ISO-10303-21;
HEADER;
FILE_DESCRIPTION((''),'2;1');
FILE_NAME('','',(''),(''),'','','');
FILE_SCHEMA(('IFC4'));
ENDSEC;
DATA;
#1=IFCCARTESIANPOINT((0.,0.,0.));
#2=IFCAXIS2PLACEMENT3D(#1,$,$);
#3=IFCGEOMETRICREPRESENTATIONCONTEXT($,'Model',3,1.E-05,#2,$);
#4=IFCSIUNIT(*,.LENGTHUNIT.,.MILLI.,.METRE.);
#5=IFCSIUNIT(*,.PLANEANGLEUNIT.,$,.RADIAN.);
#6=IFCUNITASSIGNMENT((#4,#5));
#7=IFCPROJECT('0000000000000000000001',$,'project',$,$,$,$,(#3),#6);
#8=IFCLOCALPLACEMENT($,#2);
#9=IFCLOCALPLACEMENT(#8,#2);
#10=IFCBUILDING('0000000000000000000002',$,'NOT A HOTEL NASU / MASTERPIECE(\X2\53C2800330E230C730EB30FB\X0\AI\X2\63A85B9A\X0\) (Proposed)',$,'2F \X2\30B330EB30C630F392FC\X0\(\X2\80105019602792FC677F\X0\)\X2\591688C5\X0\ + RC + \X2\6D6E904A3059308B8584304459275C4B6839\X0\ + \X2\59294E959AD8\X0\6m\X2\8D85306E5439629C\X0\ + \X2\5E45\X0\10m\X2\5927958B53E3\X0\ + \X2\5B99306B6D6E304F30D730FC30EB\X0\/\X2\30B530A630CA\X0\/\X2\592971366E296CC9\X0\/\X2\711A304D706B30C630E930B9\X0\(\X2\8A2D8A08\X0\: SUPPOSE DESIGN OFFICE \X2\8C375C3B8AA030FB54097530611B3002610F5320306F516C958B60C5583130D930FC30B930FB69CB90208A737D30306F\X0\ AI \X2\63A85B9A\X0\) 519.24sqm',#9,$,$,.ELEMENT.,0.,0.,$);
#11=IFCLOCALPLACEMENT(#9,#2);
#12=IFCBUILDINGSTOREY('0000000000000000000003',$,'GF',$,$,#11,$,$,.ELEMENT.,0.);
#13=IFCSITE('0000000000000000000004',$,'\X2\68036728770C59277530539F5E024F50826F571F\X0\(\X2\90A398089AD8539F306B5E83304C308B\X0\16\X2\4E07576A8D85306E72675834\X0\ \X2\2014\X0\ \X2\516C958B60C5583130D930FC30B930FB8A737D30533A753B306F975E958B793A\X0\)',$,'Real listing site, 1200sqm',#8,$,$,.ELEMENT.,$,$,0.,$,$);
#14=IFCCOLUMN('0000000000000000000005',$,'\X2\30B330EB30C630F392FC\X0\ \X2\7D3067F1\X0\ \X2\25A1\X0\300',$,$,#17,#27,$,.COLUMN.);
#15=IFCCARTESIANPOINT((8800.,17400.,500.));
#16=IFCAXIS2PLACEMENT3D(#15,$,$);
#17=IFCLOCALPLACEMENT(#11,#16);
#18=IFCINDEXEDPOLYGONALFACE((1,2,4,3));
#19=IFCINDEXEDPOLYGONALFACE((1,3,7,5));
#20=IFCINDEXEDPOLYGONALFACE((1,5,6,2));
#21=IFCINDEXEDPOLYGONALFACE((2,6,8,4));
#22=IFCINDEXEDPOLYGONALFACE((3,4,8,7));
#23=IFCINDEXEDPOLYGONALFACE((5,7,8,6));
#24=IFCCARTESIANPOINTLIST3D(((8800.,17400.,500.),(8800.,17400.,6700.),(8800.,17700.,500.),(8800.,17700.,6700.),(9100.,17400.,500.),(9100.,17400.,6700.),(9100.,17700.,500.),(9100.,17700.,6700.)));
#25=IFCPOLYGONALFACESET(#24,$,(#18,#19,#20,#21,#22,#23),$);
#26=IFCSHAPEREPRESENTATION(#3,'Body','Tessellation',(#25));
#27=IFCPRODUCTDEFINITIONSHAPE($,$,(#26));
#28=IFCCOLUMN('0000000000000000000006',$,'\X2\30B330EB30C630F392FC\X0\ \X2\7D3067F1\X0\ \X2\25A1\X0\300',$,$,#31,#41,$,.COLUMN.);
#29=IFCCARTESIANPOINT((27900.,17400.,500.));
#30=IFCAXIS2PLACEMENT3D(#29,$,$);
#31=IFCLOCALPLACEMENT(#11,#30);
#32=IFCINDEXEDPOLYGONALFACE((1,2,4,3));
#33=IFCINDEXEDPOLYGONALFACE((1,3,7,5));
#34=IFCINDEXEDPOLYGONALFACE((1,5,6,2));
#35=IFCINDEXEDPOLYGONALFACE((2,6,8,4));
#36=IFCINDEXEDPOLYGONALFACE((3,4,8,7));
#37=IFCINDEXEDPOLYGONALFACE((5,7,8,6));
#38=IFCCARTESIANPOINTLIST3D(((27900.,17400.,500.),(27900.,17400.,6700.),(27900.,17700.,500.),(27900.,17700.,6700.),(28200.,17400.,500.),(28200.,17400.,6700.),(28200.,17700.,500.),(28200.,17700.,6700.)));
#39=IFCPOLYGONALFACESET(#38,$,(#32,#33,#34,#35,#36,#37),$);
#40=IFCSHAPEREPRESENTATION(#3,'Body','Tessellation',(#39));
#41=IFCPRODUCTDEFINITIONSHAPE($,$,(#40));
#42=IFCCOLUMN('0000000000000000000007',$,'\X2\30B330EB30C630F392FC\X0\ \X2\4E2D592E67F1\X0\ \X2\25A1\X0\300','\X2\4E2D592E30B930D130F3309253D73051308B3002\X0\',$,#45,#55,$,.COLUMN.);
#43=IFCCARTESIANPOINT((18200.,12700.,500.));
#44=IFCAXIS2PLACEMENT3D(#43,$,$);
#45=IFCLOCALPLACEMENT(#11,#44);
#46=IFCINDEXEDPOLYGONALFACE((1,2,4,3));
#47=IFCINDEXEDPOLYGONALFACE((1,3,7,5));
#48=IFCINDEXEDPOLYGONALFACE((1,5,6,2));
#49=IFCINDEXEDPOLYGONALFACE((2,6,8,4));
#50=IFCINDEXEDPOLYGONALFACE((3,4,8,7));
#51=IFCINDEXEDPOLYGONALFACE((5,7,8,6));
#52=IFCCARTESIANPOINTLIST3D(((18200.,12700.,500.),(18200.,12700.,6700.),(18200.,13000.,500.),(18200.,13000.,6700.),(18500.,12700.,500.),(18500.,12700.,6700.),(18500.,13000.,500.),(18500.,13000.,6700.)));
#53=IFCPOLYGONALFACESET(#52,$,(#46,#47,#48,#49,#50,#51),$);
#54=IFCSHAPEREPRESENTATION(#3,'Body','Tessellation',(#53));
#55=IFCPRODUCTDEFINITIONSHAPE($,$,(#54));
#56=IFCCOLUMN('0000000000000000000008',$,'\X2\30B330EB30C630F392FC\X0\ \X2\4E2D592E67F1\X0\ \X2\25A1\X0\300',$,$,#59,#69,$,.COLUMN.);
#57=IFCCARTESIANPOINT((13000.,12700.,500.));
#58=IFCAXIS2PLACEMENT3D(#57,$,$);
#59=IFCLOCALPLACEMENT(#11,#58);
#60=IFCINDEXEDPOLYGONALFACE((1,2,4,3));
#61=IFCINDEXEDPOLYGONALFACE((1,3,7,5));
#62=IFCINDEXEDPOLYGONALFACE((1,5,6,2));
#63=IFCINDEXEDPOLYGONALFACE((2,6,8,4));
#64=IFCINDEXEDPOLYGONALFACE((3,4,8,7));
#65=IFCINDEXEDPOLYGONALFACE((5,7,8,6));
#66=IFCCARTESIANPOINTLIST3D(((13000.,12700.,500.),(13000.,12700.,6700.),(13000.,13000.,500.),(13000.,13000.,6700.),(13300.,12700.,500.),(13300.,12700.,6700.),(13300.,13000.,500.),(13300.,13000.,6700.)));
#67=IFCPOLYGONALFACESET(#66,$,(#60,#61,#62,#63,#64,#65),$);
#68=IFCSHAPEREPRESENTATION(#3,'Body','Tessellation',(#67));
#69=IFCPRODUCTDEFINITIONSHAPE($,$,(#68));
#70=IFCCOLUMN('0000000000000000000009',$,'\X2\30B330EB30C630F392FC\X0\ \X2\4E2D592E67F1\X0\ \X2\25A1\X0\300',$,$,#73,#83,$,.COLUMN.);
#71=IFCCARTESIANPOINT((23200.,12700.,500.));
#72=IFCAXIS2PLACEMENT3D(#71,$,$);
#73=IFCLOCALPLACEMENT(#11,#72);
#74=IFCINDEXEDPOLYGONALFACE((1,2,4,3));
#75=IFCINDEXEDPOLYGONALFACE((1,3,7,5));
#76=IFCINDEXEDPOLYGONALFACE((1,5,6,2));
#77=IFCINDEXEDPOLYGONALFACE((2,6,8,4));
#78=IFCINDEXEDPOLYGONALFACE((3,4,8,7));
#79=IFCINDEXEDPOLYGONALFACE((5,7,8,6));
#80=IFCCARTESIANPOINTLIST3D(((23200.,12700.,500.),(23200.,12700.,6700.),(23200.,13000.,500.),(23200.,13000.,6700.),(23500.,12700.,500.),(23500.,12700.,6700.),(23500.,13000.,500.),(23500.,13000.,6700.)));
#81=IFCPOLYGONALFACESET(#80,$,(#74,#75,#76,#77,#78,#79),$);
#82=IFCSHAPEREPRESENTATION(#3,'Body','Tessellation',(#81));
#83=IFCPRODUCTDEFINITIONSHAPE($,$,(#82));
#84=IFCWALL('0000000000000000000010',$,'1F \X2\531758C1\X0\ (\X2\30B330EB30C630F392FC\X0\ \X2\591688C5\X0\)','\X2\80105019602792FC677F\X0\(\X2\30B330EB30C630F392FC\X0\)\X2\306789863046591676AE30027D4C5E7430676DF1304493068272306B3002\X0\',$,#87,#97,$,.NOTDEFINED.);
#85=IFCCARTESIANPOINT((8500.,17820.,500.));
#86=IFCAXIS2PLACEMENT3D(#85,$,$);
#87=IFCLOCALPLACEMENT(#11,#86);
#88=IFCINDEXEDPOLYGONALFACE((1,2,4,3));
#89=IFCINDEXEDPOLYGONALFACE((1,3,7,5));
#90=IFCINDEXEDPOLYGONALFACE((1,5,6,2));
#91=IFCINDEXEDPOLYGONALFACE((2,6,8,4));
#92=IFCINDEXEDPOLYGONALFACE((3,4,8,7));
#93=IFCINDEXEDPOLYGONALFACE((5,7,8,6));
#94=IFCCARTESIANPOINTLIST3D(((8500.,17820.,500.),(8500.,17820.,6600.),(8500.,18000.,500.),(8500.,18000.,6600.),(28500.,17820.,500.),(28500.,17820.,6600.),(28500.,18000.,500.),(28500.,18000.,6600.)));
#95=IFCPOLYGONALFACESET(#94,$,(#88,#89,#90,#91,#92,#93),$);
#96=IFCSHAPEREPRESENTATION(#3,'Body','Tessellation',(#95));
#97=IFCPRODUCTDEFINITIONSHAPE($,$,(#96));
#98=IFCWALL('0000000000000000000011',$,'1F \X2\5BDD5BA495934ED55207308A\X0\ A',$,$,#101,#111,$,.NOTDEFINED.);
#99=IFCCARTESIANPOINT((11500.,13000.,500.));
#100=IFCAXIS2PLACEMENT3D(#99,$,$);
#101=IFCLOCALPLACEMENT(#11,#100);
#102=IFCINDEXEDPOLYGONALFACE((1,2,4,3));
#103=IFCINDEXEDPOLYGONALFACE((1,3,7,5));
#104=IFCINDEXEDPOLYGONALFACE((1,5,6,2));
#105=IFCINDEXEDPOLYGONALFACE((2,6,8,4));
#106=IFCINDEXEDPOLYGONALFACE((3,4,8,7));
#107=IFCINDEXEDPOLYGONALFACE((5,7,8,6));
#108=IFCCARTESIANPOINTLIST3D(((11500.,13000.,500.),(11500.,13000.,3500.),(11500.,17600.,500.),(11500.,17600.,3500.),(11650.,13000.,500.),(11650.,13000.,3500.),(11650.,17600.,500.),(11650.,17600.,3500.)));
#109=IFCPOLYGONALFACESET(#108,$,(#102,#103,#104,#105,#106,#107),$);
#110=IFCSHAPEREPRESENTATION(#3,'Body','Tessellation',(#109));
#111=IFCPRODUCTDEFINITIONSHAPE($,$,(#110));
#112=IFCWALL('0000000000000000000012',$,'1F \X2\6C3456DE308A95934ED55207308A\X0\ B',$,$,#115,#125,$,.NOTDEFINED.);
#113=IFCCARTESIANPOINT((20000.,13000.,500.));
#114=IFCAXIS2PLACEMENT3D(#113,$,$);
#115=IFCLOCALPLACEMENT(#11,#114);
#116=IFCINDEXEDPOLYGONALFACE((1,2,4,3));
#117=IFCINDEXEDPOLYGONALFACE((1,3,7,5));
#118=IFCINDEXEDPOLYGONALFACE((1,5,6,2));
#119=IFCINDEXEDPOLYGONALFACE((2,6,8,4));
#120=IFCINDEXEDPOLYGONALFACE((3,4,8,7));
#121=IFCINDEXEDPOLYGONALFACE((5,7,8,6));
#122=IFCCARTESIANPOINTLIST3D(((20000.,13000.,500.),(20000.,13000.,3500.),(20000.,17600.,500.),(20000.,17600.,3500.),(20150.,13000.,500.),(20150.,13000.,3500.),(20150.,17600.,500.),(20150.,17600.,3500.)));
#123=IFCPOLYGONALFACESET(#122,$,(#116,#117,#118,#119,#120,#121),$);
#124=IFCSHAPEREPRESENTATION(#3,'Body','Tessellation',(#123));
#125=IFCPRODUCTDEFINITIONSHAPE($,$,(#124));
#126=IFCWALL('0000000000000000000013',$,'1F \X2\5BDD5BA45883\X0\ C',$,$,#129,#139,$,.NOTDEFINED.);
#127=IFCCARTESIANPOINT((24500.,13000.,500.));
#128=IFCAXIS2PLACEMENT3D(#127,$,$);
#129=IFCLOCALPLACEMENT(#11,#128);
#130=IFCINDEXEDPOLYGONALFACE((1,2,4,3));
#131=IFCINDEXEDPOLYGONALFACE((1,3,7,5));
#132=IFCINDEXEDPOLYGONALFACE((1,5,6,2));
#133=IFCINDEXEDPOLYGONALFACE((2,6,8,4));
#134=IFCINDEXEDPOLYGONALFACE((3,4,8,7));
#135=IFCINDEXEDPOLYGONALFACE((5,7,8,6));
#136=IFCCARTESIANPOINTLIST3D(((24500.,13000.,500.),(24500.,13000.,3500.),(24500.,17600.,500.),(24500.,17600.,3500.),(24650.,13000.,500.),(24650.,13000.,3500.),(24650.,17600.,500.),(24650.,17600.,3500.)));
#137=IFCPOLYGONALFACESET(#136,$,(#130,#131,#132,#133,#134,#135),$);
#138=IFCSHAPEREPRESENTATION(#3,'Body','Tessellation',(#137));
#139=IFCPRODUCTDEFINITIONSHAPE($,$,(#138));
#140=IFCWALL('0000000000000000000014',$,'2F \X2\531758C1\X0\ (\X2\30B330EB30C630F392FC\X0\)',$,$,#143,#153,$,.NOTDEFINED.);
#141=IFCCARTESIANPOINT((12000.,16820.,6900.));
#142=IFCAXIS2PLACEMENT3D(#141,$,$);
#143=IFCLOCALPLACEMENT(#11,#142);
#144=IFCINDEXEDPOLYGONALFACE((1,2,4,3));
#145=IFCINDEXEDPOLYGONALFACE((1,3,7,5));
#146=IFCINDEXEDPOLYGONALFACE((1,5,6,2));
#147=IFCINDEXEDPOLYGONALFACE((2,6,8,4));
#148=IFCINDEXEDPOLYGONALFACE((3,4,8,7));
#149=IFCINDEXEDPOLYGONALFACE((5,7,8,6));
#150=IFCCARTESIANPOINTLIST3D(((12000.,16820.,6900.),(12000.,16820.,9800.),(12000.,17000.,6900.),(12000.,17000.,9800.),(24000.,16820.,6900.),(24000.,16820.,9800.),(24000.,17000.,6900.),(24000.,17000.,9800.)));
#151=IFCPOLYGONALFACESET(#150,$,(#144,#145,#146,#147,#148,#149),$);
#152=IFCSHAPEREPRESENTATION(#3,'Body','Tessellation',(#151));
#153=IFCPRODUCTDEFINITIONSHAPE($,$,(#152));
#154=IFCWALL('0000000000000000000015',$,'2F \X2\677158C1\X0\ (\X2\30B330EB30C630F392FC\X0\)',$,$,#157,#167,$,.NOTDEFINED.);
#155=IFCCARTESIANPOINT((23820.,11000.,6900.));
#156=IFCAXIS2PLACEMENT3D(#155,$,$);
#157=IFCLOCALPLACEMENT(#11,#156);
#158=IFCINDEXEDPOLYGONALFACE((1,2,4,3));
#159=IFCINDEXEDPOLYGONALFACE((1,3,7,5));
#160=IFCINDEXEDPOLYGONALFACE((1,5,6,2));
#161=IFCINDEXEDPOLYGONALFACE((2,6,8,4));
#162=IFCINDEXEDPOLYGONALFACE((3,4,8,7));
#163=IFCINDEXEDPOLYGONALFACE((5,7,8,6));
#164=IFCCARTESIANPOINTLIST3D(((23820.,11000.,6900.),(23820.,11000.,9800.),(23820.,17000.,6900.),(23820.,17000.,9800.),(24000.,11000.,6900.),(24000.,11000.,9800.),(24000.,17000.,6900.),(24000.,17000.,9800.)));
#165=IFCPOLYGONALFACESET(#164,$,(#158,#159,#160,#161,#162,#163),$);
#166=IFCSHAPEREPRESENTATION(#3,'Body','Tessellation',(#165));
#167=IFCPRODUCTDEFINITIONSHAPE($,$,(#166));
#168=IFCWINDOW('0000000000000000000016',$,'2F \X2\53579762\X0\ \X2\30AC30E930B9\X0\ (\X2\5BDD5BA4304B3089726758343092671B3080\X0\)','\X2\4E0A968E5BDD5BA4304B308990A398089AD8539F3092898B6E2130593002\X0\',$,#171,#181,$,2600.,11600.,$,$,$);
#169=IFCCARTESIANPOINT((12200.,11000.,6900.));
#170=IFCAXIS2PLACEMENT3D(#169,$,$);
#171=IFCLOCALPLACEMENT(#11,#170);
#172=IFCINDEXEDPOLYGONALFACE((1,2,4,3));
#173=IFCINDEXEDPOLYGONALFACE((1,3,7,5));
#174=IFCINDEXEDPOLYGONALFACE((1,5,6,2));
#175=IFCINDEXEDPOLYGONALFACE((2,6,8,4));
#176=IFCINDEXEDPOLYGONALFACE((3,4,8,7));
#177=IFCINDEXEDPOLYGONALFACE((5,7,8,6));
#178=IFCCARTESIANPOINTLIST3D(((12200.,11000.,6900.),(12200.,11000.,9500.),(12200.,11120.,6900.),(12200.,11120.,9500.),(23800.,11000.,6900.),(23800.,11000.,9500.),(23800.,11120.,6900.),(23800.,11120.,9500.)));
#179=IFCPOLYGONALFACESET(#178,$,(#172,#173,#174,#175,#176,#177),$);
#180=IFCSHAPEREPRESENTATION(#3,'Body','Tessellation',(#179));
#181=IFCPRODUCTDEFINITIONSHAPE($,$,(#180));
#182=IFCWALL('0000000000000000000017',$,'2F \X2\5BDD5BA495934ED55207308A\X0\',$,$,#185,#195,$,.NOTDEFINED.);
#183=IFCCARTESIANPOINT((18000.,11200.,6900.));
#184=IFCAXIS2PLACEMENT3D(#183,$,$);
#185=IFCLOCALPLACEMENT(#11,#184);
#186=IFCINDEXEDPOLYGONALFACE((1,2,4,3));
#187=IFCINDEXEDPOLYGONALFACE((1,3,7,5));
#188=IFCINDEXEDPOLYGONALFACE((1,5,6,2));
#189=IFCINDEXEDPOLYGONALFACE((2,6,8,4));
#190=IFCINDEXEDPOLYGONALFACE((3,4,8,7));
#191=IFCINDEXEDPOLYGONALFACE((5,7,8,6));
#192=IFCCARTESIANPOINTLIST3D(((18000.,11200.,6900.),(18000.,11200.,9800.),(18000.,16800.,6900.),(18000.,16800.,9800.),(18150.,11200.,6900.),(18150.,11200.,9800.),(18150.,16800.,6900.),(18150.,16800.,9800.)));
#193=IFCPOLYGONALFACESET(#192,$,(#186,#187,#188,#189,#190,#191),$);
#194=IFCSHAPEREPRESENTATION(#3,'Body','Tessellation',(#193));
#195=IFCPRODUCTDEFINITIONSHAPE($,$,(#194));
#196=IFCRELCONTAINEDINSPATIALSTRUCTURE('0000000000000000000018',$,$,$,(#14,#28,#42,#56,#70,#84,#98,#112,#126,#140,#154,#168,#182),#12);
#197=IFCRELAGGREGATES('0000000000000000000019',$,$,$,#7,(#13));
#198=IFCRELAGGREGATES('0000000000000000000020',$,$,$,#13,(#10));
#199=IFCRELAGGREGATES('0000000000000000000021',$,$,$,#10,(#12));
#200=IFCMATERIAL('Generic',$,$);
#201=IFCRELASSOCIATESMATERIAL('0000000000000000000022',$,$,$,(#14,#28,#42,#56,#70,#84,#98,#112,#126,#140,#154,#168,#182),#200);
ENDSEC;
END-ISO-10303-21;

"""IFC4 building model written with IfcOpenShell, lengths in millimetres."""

from ifc_helpers import new_model, si_unit, frame, frame_2d, origin, place, context, project, spatial, rectangle, extrude, material, element, save


model = new_model("IFC4")

# Units and contexts
model_context = context("Model", 3, precision=1e-05, world=origin())
ifc_project = project(units=[si_unit("LENGTHUNIT", "METRE", prefix="MILLI"), si_unit("PLANEANGLEUNIT", "RADIAN")], contexts=[model_context])

# Site, building, storey
site_placement = place(None, origin())
site = spatial("IfcSite", under=ifc_project, at=site_placement, Name="栃木県大田原市佐良土(那須高原に広がる16万坪超の牧場 — 公開情報ベース・詳細区画は非開示)", ObjectType="Real listing site, 1200sqm", CompositionType="ELEMENT", RefElevation=0.0)
building_placement = place(site_placement, origin())
building = spatial("IfcBuilding", under=site, at=building_placement, Name="NOT A HOTEL NASU / MASTERPIECE(参考モデル・AI推定) (Proposed)", ObjectType="2F コルテン鋼(耐候性鋼板)外装 + RC + 浮遊する薄い大屋根 + 天井高6m超の吹抜 + 幅10m大開口 + 宙に浮くプール/サウナ/天然温泉/焚き火テラス(設計: SUPPOSE DESIGN OFFICE 谷尻誠・吉田愛。意匠は公開情報ベース・構造詳細は AI 推定) 519.24sqm", CompositionType="ELEMENT", ElevationOfRefHeight=0.0, ElevationOfTerrain=0.0)
storey_placement = place(building_placement, origin())
storey = spatial("IfcBuildingStorey", under=building, at=storey_placement, Name="GF", CompositionType="ELEMENT", Elevation=0.0)

# Columns
ifc_material_1 = material(Name="Generic")
column_1_placement = place(storey_placement, frame((8800.0, 17400.0, 500.0)))
element("IfcColumn", 1, at=column_1_placement, inside=storey, material=ifc_material_1, Name="コルテン鋼 細柱 □300", PredefinedType="COLUMN", context=model_context, shape_type="SweptSolid", body=[
    extrude(rectangle(XDim=300.0, YDim=300.0, at=frame_2d((150.0, 150.0))), frame((8800.0, 17400.0, 500.0)), (0.0, 0.0, 1.0), 6200.0),
])
column_2_placement = place(storey_placement, frame((27900.0, 17400.0, 500.0)))
element("IfcColumn", 2, at=column_2_placement, inside=storey, material=ifc_material_1, Name="コルテン鋼 細柱 □300", PredefinedType="COLUMN", context=model_context, shape_type="SweptSolid", body=[
    extrude(rectangle(XDim=300.0, YDim=300.0, at=frame_2d((150.0, 150.0))), frame((27900.0, 17400.0, 500.0)), (0.0, 0.0, 1.0), 6200.0),
])
column_3_placement = place(storey_placement, frame((18200.0, 12700.0, 500.0)))
element("IfcColumn", 3, at=column_3_placement, inside=storey, material=ifc_material_1, Name="コルテン鋼 中央柱 □300", Description="中央スパンを受ける。", PredefinedType="COLUMN", context=model_context, shape_type="SweptSolid", body=[
    extrude(rectangle(XDim=300.0, YDim=300.0, at=frame_2d((150.0, 150.0))), frame((18200.0, 12700.0, 500.0)), (0.0, 0.0, 1.0), 6200.0),
])
column_4_placement = place(storey_placement, frame((13000.0, 12700.0, 500.0)))
element("IfcColumn", 4, at=column_4_placement, inside=storey, material=ifc_material_1, Name="コルテン鋼 中央柱 □300", PredefinedType="COLUMN", context=model_context, shape_type="SweptSolid", body=[
    extrude(rectangle(XDim=300.0, YDim=300.0, at=frame_2d((150.0, 150.0))), frame((13000.0, 12700.0, 500.0)), (0.0, 0.0, 1.0), 6200.0),
])
column_5_placement = place(storey_placement, frame((23200.0, 12700.0, 500.0)))
element("IfcColumn", 5, at=column_5_placement, inside=storey, material=ifc_material_1, Name="コルテン鋼 中央柱 □300", PredefinedType="COLUMN", context=model_context, shape_type="SweptSolid", body=[
    extrude(rectangle(XDim=300.0, YDim=300.0, at=frame_2d((150.0, 150.0))), frame((23200.0, 12700.0, 500.0)), (0.0, 0.0, 1.0), 6200.0),
])

# Walls
wall_1_placement = place(storey_placement, frame((8500.0, 17820.0, 500.0)))
element("IfcWall", 6, at=wall_1_placement, inside=storey, material=ifc_material_1, Name="1F 北壁 (コルテン鋼 外装)", Description="耐候性鋼板(コルテン鋼)で覆う外皮。経年で深い錆色に。", PredefinedType="NOTDEFINED", context=model_context, shape_type="SweptSolid", body=[
    extrude(rectangle(XDim=20000.0, YDim=180.0, at=frame_2d((10000.0, 90.0))), frame((8500.0, 17820.0, 500.0)), (0.0, 0.0, 1.0), 6100.0),
])
wall_2_placement = place(storey_placement, frame((11500.0, 13000.0, 500.0)))
element("IfcWall", 7, at=wall_2_placement, inside=storey, material=ifc_material_1, Name="1F 寝室間仕切り A", PredefinedType="NOTDEFINED", context=model_context, shape_type="SweptSolid", body=[
    extrude(rectangle(XDim=150.0, YDim=4600.0, at=frame_2d((75.0, 2300.0))), frame((11500.0, 13000.0, 500.0)), (0.0, 0.0, 1.0), 3000.0),
])
wall_3_placement = place(storey_placement, frame((20000.0, 13000.0, 500.0)))
element("IfcWall", 8, at=wall_3_placement, inside=storey, material=ifc_material_1, Name="1F 水回り間仕切り B", PredefinedType="NOTDEFINED", context=model_context, shape_type="SweptSolid", body=[
    extrude(rectangle(XDim=150.0, YDim=4600.0, at=frame_2d((75.0, 2300.0))), frame((20000.0, 13000.0, 500.0)), (0.0, 0.0, 1.0), 3000.0),
])
wall_4_placement = place(storey_placement, frame((24500.0, 13000.0, 500.0)))
element("IfcWall", 9, at=wall_4_placement, inside=storey, material=ifc_material_1, Name="1F 寝室境 C", PredefinedType="NOTDEFINED", context=model_context, shape_type="SweptSolid", body=[
    extrude(rectangle(XDim=150.0, YDim=4600.0, at=frame_2d((75.0, 2300.0))), frame((24500.0, 13000.0, 500.0)), (0.0, 0.0, 1.0), 3000.0),
])
wall_5_placement = place(storey_placement, frame((12000.0, 16820.0, 6900.0)))
element("IfcWall", 10, at=wall_5_placement, inside=storey, material=ifc_material_1, Name="2F 北壁 (コルテン鋼)", PredefinedType="NOTDEFINED", context=model_context, shape_type="SweptSolid", body=[
    extrude(rectangle(XDim=12000.0, YDim=180.0, at=frame_2d((6000.0, 90.0))), frame((12000.0, 16820.0, 6900.0)), (0.0, 0.0, 1.0), 2900.0),
])
wall_6_placement = place(storey_placement, frame((23820.0, 11000.0, 6900.0)))
element("IfcWall", 11, at=wall_6_placement, inside=storey, material=ifc_material_1, Name="2F 東壁 (コルテン鋼)", PredefinedType="NOTDEFINED", context=model_context, shape_type="SweptSolid", body=[
    extrude(rectangle(XDim=180.0, YDim=6000.0, at=frame_2d((90.0, 3000.0))), frame((23820.0, 11000.0, 6900.0)), (0.0, 0.0, 1.0), 2900.0),
])

# Window
window_placement = place(storey_placement, frame((12200.0, 11000.0, 6900.0)))
element("IfcWindow", 12, at=window_placement, inside=storey, material=ifc_material_1, Name="2F 南面 ガラス (寝室から牧場を望む)", Description="上階寝室から那須高原を見渡す。", OverallHeight=2600.0, OverallWidth=11600.0, context=model_context, shape_type="SweptSolid", body=[
    extrude(rectangle(XDim=11600.0, YDim=120.0, at=frame_2d((5800.0, 60.0))), frame((12200.0, 11000.0, 6900.0)), (0.0, 0.0, 1.0), 2600.0),
])

# Wall
wall_7_placement = place(storey_placement, frame((18000.0, 11200.0, 6900.0)))
element("IfcWall", 13, at=wall_7_placement, inside=storey, material=ifc_material_1, Name="2F 寝室間仕切り", PredefinedType="NOTDEFINED", context=model_context, shape_type="SweptSolid", body=[
    extrude(rectangle(XDim=150.0, YDim=5600.0, at=frame_2d((75.0, 2800.0))), frame((18000.0, 11200.0, 6900.0)), (0.0, 0.0, 1.0), 2900.0),
])

save(model, "model.ifc")
